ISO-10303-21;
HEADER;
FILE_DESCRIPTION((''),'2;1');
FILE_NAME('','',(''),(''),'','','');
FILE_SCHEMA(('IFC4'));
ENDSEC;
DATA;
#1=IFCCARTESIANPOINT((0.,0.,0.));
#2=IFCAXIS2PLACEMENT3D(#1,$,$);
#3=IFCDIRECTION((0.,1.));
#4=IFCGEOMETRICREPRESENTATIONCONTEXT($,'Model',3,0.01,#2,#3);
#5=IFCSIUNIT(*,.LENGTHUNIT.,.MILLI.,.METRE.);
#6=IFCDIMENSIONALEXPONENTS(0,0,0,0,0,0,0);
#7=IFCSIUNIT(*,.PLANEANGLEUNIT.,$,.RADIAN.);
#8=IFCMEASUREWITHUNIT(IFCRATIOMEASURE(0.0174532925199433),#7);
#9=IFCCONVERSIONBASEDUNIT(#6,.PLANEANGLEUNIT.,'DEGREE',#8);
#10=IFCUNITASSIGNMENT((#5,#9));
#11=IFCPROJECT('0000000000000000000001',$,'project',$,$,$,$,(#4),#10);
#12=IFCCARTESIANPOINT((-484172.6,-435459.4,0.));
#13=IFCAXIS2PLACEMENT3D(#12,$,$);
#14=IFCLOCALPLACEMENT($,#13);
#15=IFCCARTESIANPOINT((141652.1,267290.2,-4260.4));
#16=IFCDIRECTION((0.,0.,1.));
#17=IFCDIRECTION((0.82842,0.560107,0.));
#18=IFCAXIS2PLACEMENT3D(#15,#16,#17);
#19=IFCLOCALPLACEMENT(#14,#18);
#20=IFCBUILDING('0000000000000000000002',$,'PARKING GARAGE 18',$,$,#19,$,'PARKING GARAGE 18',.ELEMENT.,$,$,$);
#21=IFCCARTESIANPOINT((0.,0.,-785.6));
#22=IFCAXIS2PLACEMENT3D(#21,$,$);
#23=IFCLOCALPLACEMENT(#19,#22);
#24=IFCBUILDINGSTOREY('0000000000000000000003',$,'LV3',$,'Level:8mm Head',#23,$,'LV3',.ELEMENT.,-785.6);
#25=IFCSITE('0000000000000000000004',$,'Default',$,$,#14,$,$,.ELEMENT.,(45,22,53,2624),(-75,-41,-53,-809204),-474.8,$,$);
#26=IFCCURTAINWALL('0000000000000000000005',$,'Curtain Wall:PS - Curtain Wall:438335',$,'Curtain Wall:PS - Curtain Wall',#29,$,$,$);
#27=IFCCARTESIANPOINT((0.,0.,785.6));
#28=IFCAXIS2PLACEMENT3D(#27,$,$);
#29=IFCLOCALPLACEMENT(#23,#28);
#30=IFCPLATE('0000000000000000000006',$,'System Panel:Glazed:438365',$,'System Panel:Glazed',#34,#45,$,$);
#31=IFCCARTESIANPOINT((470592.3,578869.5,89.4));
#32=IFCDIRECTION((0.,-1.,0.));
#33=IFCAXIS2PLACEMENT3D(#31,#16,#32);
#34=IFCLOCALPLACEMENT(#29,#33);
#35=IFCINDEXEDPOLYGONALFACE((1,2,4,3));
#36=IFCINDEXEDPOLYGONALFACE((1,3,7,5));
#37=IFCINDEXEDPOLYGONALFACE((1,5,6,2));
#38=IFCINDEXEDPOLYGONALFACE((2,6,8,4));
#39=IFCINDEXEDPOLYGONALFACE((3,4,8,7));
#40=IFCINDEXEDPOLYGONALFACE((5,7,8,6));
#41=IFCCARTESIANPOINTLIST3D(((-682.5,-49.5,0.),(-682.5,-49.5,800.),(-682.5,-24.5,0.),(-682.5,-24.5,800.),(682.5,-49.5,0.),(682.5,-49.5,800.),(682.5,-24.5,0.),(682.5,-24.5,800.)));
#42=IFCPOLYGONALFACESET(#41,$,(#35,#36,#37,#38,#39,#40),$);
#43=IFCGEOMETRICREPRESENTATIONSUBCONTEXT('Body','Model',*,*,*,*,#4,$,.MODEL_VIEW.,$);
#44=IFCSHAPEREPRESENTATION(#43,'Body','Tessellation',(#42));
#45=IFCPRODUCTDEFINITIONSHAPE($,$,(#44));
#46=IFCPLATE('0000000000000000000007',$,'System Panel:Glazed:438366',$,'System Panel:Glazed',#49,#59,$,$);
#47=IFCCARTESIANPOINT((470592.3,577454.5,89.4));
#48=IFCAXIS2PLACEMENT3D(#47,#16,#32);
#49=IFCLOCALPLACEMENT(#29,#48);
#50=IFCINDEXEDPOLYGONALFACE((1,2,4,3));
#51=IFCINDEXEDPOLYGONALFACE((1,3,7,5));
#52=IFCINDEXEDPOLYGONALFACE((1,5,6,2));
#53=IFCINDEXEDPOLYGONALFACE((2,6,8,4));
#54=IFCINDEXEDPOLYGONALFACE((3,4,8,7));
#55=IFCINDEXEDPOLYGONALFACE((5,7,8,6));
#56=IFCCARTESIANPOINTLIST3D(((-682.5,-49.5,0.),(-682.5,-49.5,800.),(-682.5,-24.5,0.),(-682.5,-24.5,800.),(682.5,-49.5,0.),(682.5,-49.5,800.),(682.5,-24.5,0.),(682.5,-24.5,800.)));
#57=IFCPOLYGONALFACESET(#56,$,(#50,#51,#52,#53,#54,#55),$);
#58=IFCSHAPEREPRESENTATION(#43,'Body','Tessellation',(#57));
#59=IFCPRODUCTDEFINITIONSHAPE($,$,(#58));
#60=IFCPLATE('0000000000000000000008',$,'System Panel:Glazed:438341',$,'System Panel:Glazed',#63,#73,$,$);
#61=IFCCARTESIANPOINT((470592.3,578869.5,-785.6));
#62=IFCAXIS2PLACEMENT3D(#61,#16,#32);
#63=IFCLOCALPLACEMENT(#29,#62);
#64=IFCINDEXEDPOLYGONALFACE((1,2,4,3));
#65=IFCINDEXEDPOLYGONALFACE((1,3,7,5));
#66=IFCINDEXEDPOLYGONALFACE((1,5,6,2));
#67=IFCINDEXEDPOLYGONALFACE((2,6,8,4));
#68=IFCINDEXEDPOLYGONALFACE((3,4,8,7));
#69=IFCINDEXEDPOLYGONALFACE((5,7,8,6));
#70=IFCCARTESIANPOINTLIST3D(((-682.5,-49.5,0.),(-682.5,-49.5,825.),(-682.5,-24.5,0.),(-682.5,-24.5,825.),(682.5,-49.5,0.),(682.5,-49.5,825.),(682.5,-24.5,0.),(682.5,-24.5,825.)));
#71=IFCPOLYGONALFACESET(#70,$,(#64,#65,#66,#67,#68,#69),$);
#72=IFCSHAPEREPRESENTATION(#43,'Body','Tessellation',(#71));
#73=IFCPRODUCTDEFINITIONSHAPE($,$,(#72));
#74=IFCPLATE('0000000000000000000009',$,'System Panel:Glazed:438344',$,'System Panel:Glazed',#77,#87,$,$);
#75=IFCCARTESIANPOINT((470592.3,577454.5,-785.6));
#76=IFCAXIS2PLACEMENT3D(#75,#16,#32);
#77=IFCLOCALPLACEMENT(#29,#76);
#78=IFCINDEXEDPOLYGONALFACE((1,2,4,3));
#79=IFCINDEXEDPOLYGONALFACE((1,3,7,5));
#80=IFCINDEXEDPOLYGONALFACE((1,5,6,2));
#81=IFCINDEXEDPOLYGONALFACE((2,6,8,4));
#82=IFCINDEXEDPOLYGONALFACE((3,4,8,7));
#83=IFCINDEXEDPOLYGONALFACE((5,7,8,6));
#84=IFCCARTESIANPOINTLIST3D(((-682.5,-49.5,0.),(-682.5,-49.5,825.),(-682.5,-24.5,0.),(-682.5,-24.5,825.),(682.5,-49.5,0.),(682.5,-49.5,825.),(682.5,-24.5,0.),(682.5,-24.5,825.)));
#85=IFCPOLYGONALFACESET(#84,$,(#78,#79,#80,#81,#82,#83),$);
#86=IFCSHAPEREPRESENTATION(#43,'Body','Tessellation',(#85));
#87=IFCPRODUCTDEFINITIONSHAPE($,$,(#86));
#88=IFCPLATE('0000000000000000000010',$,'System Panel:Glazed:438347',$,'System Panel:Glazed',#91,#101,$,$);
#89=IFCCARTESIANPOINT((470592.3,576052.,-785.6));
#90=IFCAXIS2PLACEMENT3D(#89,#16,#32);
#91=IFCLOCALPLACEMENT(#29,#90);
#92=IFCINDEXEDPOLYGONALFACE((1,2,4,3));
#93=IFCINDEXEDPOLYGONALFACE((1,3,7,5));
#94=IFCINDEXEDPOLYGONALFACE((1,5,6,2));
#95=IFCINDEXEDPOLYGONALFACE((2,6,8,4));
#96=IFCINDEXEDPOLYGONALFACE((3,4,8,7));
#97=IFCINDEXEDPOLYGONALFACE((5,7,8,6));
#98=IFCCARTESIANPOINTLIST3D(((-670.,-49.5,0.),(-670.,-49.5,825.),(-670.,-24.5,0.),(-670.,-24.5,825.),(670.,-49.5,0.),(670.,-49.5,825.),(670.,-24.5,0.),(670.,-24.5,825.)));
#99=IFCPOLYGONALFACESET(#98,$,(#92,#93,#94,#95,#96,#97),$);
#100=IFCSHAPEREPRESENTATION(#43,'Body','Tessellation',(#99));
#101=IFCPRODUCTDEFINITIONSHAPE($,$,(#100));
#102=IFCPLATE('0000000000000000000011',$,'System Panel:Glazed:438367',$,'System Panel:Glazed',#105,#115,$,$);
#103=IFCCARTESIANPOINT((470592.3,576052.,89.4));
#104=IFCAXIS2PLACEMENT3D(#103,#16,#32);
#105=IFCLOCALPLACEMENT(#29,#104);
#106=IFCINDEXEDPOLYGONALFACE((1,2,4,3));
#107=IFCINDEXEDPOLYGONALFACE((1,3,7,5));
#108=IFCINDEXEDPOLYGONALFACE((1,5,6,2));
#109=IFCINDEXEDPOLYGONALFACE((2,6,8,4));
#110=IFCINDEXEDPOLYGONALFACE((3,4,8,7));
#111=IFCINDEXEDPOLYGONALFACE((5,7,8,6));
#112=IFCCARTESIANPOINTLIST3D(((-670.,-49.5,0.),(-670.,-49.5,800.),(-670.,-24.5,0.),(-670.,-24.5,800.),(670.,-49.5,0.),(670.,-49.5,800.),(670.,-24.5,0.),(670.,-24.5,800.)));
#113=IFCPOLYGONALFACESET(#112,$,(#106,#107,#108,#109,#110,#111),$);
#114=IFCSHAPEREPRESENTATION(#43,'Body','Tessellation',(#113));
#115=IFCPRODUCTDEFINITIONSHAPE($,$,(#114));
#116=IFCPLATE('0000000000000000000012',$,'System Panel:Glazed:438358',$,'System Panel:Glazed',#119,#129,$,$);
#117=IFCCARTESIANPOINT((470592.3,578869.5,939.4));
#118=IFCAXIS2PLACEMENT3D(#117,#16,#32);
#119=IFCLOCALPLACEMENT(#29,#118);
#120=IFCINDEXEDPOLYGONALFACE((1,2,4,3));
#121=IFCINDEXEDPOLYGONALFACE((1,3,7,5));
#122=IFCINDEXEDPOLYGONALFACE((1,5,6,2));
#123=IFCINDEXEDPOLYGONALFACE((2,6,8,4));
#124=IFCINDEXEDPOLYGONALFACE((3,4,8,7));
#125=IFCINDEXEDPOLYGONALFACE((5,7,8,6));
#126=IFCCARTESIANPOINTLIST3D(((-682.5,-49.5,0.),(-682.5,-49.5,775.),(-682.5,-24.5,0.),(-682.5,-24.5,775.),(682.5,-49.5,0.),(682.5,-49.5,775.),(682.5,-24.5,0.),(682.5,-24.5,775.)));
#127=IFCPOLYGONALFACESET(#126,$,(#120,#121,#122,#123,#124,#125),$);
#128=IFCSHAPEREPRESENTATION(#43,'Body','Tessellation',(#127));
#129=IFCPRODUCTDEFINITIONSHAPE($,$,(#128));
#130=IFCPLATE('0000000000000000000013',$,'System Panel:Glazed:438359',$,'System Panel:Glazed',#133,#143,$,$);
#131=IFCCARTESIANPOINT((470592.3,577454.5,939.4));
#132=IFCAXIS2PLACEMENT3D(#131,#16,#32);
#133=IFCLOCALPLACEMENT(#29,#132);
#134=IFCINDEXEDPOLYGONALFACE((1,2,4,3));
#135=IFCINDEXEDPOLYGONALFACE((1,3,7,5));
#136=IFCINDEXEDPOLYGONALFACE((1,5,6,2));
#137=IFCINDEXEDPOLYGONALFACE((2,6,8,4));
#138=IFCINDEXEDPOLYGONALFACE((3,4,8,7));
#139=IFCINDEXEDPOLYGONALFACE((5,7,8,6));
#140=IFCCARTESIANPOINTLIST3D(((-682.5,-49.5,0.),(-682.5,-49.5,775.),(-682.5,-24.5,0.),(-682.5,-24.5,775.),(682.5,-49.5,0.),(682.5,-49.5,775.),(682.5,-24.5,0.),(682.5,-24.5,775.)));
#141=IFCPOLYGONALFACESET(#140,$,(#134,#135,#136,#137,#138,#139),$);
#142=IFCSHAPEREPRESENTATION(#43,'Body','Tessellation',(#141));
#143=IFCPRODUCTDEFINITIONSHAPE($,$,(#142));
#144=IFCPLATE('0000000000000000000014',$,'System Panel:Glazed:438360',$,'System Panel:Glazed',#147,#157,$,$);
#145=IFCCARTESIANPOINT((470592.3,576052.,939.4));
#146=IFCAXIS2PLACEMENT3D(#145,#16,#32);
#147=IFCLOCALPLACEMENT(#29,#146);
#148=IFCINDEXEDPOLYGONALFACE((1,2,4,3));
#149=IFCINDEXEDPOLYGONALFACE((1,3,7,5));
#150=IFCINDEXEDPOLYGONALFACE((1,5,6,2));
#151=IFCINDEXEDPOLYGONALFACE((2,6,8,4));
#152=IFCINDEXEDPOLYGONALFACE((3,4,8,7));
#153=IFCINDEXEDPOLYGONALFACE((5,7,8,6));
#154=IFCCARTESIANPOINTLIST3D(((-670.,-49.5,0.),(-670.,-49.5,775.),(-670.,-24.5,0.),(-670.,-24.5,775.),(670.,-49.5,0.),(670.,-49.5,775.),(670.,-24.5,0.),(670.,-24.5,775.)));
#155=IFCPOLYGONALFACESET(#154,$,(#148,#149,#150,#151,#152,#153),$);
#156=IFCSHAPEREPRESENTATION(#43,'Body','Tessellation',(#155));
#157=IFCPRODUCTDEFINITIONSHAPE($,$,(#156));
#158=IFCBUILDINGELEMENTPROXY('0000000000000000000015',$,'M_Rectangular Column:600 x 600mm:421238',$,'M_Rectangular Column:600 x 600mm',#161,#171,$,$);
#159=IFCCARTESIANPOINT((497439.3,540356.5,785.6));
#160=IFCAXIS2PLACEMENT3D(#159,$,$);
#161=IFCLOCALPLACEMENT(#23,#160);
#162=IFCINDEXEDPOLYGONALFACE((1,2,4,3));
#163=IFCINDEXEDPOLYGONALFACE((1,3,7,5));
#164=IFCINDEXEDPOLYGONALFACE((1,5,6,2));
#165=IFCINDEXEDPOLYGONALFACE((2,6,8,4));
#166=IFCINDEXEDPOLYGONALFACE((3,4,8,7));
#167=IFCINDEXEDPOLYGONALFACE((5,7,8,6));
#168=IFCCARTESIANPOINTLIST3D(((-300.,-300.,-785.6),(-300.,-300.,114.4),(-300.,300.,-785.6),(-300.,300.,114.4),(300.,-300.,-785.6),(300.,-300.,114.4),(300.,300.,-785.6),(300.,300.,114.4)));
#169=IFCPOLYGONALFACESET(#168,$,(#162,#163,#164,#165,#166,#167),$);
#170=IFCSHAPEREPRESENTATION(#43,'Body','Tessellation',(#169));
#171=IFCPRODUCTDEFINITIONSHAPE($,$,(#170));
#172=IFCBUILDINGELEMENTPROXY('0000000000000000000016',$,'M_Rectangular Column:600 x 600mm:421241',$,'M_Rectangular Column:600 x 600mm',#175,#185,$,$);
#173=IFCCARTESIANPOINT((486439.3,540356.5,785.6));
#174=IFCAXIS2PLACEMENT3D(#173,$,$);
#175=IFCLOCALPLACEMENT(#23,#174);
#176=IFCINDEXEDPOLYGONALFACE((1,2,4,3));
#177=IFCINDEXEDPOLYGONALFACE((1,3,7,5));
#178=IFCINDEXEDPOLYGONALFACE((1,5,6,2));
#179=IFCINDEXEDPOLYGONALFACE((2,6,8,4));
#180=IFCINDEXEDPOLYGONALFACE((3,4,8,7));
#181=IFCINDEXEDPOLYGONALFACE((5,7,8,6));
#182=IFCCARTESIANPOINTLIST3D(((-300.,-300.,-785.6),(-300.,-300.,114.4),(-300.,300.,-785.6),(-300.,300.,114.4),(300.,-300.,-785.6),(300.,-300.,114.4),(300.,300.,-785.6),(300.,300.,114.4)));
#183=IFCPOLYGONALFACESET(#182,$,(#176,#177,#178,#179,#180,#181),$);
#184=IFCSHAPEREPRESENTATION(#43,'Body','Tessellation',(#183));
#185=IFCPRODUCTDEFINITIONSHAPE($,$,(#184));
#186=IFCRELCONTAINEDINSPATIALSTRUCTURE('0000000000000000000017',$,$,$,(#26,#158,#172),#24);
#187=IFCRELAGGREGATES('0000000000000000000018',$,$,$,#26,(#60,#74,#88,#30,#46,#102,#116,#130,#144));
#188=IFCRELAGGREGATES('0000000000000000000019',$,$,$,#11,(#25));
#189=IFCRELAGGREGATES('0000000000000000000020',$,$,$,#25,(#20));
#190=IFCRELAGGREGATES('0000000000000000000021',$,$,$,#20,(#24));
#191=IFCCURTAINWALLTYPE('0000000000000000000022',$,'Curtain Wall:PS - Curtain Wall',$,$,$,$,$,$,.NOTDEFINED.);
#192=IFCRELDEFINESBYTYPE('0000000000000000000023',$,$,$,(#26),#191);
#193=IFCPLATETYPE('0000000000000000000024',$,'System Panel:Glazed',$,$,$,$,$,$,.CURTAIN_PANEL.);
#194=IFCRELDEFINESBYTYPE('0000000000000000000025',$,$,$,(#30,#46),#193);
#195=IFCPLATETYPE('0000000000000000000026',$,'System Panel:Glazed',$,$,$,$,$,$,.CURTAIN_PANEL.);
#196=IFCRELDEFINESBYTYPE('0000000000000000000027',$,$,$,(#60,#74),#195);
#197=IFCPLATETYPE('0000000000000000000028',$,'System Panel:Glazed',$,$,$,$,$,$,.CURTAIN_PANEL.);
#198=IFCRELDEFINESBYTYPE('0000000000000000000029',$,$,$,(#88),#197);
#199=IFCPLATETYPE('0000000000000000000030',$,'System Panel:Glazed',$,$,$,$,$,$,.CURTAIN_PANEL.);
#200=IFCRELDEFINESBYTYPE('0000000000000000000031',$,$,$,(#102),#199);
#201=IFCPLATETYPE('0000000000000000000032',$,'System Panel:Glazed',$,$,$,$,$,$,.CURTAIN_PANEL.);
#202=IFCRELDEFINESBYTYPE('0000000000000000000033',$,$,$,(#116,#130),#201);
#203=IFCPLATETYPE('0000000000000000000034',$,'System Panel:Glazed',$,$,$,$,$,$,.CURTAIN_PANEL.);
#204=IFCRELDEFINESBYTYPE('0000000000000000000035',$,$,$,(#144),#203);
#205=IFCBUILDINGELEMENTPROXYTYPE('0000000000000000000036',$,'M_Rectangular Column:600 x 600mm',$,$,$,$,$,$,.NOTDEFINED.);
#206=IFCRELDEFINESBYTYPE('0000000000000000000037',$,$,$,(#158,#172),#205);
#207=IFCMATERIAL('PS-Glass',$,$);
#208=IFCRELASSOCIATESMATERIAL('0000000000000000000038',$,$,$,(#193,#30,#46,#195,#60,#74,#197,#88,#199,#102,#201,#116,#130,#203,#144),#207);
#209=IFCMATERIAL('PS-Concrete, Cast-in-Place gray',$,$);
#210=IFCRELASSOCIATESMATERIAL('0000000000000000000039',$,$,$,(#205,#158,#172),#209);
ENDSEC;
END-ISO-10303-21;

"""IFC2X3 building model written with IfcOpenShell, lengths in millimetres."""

from ifc_helpers import new_model, entity, si_unit, converted_unit, direction, frame, frame_2d, origin, origin_2d_with_axis, place, context, subcontext, project, spatial, rectangle, extrude, source, transform, mapped, material, type_object, type_shapes, element, aggregate, save


model = new_model("IFC2X3")

# Units and contexts
model_context = context("Model", 3, precision=0.01, world=origin(), true_north=direction((0.0, 1.0)))
body_context = subcontext(model_context, "Body", "Model", "MODEL_VIEW")
ifc_project = project(units=[si_unit("LENGTHUNIT", "METRE", prefix="MILLI"), converted_unit("PLANEANGLEUNIT", "DEGREE", entity("IfcRatioMeasure", 0.0174532925199433), si_unit("PLANEANGLEUNIT", "RADIAN"), dimensions=[0, 0, 0, 0, 0, 0, 0])], contexts=[model_context])

# Site, building, storey
site_placement = place(None, frame((-484172.6, -435459.4, 0.0)))
site = spatial("IfcSite", under=ifc_project, at=site_placement, Name="Default", CompositionType="ELEMENT", RefLatitude=(45, 22, 53, 2624), RefLongitude=(-75, -41, -53, -809204), RefElevation=-474.8)
building_placement = place(site_placement, frame((141652.1, 267290.2, -4260.4), z_axis=(0.0, 0.0, 1.0), x_axis=(0.82842, 0.560107, 0.0)))
building = spatial("IfcBuilding", under=site, at=building_placement, Name="PARKING GARAGE 18", LongName="PARKING GARAGE 18", CompositionType="ELEMENT")
storey_placement = place(building_placement, frame((0.0, 0.0, -785.6)))
storey = spatial("IfcBuildingStorey", under=building, at=storey_placement, Name="LV3", ObjectType="Level:8mm Head", LongName="LV3", CompositionType="ELEMENT", Elevation=-785.6)

# Curtain wall, plates
curtain_wall_type = type_object("IfcCurtainWallType", Name="Curtain Wall:PS - Curtain Wall", PredefinedType="NOTDEFINED")
curtain_wall_placement = place(storey_placement, frame((0.0, 0.0, 785.6)))
curtain_wall = element("IfcCurtainWall", 1, at=curtain_wall_placement, inside=storey, type_object=curtain_wall_type, Name="Curtain Wall:PS - Curtain Wall:438335", ObjectType="Curtain Wall:PS - Curtain Wall")
ifc_material_1 = material(Name="PS-Glass")
plate_type_1 = type_object("IfcPlateType", Name="System Panel:Glazed", PredefinedType="CURTAIN_PANEL", material=ifc_material_1)
shared_shape_1 = source(origin(), body_context, "Body", "SweptSolid", [
    extrude(rectangle(XDim=25.0, YDim=1365.0, at=frame_2d((0.0, 0.0), x_axis=(1.0, 0.0))), frame((0.0, -37.0, 0.0), z_axis=(0.0, 0.0, 1.0), x_axis=(0.0, 1.0, 0.0)), (0.0, 0.0, 1.0), 800.0),
])
type_shapes(plate_type_1, [shared_shape_1])
plate_1_placement = place(curtain_wall_placement, frame((470592.3, 578869.5, 89.4), z_axis=(0.0, 0.0, 1.0), x_axis=(0.0, -1.0, 0.0)))
plate_1 = element("IfcPlate", 2, at=plate_1_placement, type_object=plate_type_1, material=ifc_material_1, Name="System Panel:Glazed:438365", ObjectType="System Panel:Glazed", context=body_context, shape_type="MappedRepresentation", body=[
    mapped(shared_shape_1, transform((0.0, 0.0, 0.0), scale=1.0)),
])
plate_2_placement = place(curtain_wall_placement, frame((470592.3, 577454.5, 89.4), z_axis=(0.0, 0.0, 1.0), x_axis=(0.0, -1.0, 0.0)))
plate_2 = element("IfcPlate", 3, at=plate_2_placement, type_object=plate_type_1, material=ifc_material_1, Name="System Panel:Glazed:438366", ObjectType="System Panel:Glazed", context=body_context, shape_type="MappedRepresentation", body=[
    mapped(shared_shape_1, transform((0.0, 0.0, 0.0), scale=1.0)),
])
plate_type_2 = type_object("IfcPlateType", Name="System Panel:Glazed", PredefinedType="CURTAIN_PANEL", material=ifc_material_1)
shared_shape_2 = source(origin(), body_context, "Body", "SweptSolid", [
    extrude(rectangle(XDim=25.0, YDim=1365.0, at=frame_2d((0.0, 0.0), x_axis=(1.0, 0.0))), frame((0.0, -37.0, 0.0), z_axis=(0.0, 0.0, 1.0), x_axis=(0.0, 1.0, 0.0)), (0.0, 0.0, 1.0), 825.0),
])
type_shapes(plate_type_2, [shared_shape_2])
plate_3_placement = place(curtain_wall_placement, frame((470592.3, 578869.5, -785.6), z_axis=(0.0, 0.0, 1.0), x_axis=(0.0, -1.0, 0.0)))
plate_3 = element("IfcPlate", 4, at=plate_3_placement, type_object=plate_type_2, material=ifc_material_1, Name="System Panel:Glazed:438341", ObjectType="System Panel:Glazed", context=body_context, shape_type="MappedRepresentation", body=[
    mapped(shared_shape_2, transform((0.0, 0.0, 0.0), scale=1.0)),
])
plate_4_placement = place(curtain_wall_placement, frame((470592.3, 577454.5, -785.6), z_axis=(0.0, 0.0, 1.0), x_axis=(0.0, -1.0, 0.0)))
plate_4 = element("IfcPlate", 5, at=plate_4_placement, type_object=plate_type_2, material=ifc_material_1, Name="System Panel:Glazed:438344", ObjectType="System Panel:Glazed", context=body_context, shape_type="MappedRepresentation", body=[
    mapped(shared_shape_2, transform((0.0, 0.0, 0.0), scale=1.0)),
])
plate_type_3 = type_object("IfcPlateType", Name="System Panel:Glazed", PredefinedType="CURTAIN_PANEL", material=ifc_material_1)
shared_shape_3 = source(origin(), body_context, "Body", "SweptSolid", [
    extrude(rectangle(XDim=25.0, YDim=1340.0, at=origin_2d_with_axis()), frame((0.0, -37.0, 0.0), z_axis=(0.0, 0.0, 1.0), x_axis=(0.0, 1.0, 0.0)), (0.0, 0.0, 1.0), 825.0),
])
type_shapes(plate_type_3, [shared_shape_3])
plate_5_placement = place(curtain_wall_placement, frame((470592.3, 576052.0, -785.6), z_axis=(0.0, 0.0, 1.0), x_axis=(0.0, -1.0, 0.0)))
plate_5 = element("IfcPlate", 6, at=plate_5_placement, type_object=plate_type_3, material=ifc_material_1, Name="System Panel:Glazed:438347", ObjectType="System Panel:Glazed", context=body_context, shape_type="MappedRepresentation", body=[
    mapped(shared_shape_3, transform((0.0, 0.0, 0.0), scale=1.0)),
])
plate_type_4 = type_object("IfcPlateType", Name="System Panel:Glazed", PredefinedType="CURTAIN_PANEL", material=ifc_material_1)
shared_shape_4 = source(origin(), body_context, "Body", "SweptSolid", [
    extrude(rectangle(XDim=25.0, YDim=1340.0, at=origin_2d_with_axis()), frame((0.0, -37.0, 0.0), z_axis=(0.0, 0.0, 1.0), x_axis=(0.0, 1.0, 0.0)), (0.0, 0.0, 1.0), 800.0),
])
type_shapes(plate_type_4, [shared_shape_4])
plate_6_placement = place(curtain_wall_placement, frame((470592.3, 576052.0, 89.4), z_axis=(0.0, 0.0, 1.0), x_axis=(0.0, -1.0, 0.0)))
plate_6 = element("IfcPlate", 7, at=plate_6_placement, type_object=plate_type_4, material=ifc_material_1, Name="System Panel:Glazed:438367", ObjectType="System Panel:Glazed", context=body_context, shape_type="MappedRepresentation", body=[
    mapped(shared_shape_4, transform((0.0, 0.0, 0.0), scale=1.0)),
])
plate_type_5 = type_object("IfcPlateType", Name="System Panel:Glazed", PredefinedType="CURTAIN_PANEL", material=ifc_material_1)
shared_shape_5 = source(origin(), body_context, "Body", "SweptSolid", [
    extrude(rectangle(XDim=25.0, YDim=1365.0, at=frame_2d((0.0, 0.0), x_axis=(1.0, 0.0))), frame((0.0, -37.0, 0.0), z_axis=(0.0, 0.0, 1.0), x_axis=(0.0, 1.0, 0.0)), (0.0, 0.0, 1.0), 775.0),
])
type_shapes(plate_type_5, [shared_shape_5])
plate_7_placement = place(curtain_wall_placement, frame((470592.3, 578869.5, 939.4), z_axis=(0.0, 0.0, 1.0), x_axis=(0.0, -1.0, 0.0)))
plate_7 = element("IfcPlate", 8, at=plate_7_placement, type_object=plate_type_5, material=ifc_material_1, Name="System Panel:Glazed:438358", ObjectType="System Panel:Glazed", context=body_context, shape_type="MappedRepresentation", body=[
    mapped(shared_shape_5, transform((0.0, 0.0, 0.0), scale=1.0)),
])
plate_8_placement = place(curtain_wall_placement, frame((470592.3, 577454.5, 939.4), z_axis=(0.0, 0.0, 1.0), x_axis=(0.0, -1.0, 0.0)))
plate_8 = element("IfcPlate", 9, at=plate_8_placement, type_object=plate_type_5, material=ifc_material_1, Name="System Panel:Glazed:438359", ObjectType="System Panel:Glazed", context=body_context, shape_type="MappedRepresentation", body=[
    mapped(shared_shape_5, transform((0.0, 0.0, 0.0), scale=1.0)),
])
plate_type_6 = type_object("IfcPlateType", Name="System Panel:Glazed", PredefinedType="CURTAIN_PANEL", material=ifc_material_1)
shared_shape_6 = source(origin(), body_context, "Body", "SweptSolid", [
    extrude(rectangle(XDim=25.0, YDim=1340.0, at=origin_2d_with_axis()), frame((0.0, -37.0, 0.0), z_axis=(0.0, 0.0, 1.0), x_axis=(0.0, 1.0, 0.0)), (0.0, 0.0, 1.0), 775.0),
])
type_shapes(plate_type_6, [shared_shape_6])
plate_9_placement = place(curtain_wall_placement, frame((470592.3, 576052.0, 939.4), z_axis=(0.0, 0.0, 1.0), x_axis=(0.0, -1.0, 0.0)))
plate_9 = element("IfcPlate", 10, at=plate_9_placement, type_object=plate_type_6, material=ifc_material_1, Name="System Panel:Glazed:438360", ObjectType="System Panel:Glazed", context=body_context, shape_type="MappedRepresentation", body=[
    mapped(shared_shape_6, transform((0.0, 0.0, 0.0), scale=1.0)),
])
aggregate(curtain_wall, [plate_3, plate_4, plate_5, plate_1, plate_2, plate_6, plate_7, plate_8, plate_9])

# Shared definitions
ifc_material_2 = material(Name="PS-Concrete, Cast-in-Place gray")

# Building element proxies
building_element_proxy_type_1 = type_object("IfcBuildingElementProxyType", Name="M_Rectangular Column:600 x 600mm", PredefinedType="NOTDEFINED", material=ifc_material_2)
shared_shape_7 = source(origin(), body_context, "Body", "SweptSolid", [
    extrude(rectangle(XDim=600.0, YDim=600.0, at=origin_2d_with_axis()), frame((0.0, 0.0, -785.6), z_axis=(0.0, 0.0, 1.0), x_axis=(-1.0, 0.0, 0.0)), (0.0, 0.0, 1.0), 900.0),
])
type_shapes(building_element_proxy_type_1, [shared_shape_7])
for number, where, name in (
    (11, (497439.3, 540356.5, 785.6), "M_Rectangular Column:600 x 600mm:421238"),
    (12, (486439.3, 540356.5, 785.6), "M_Rectangular Column:600 x 600mm:421241"),
):
    element("IfcBuildingElementProxy", number, at=place(storey_placement, frame(where)), inside=storey, type_object=building_element_proxy_type_1, material=ifc_material_2, Name=name, ObjectType="M_Rectangular Column:600 x 600mm", context=body_context, shape_type="MappedRepresentation", body=[
        mapped(shared_shape_7, transform((0.0, 0.0, 0.0), scale=1.0)),
    ])

save(model, "model.ifc")
